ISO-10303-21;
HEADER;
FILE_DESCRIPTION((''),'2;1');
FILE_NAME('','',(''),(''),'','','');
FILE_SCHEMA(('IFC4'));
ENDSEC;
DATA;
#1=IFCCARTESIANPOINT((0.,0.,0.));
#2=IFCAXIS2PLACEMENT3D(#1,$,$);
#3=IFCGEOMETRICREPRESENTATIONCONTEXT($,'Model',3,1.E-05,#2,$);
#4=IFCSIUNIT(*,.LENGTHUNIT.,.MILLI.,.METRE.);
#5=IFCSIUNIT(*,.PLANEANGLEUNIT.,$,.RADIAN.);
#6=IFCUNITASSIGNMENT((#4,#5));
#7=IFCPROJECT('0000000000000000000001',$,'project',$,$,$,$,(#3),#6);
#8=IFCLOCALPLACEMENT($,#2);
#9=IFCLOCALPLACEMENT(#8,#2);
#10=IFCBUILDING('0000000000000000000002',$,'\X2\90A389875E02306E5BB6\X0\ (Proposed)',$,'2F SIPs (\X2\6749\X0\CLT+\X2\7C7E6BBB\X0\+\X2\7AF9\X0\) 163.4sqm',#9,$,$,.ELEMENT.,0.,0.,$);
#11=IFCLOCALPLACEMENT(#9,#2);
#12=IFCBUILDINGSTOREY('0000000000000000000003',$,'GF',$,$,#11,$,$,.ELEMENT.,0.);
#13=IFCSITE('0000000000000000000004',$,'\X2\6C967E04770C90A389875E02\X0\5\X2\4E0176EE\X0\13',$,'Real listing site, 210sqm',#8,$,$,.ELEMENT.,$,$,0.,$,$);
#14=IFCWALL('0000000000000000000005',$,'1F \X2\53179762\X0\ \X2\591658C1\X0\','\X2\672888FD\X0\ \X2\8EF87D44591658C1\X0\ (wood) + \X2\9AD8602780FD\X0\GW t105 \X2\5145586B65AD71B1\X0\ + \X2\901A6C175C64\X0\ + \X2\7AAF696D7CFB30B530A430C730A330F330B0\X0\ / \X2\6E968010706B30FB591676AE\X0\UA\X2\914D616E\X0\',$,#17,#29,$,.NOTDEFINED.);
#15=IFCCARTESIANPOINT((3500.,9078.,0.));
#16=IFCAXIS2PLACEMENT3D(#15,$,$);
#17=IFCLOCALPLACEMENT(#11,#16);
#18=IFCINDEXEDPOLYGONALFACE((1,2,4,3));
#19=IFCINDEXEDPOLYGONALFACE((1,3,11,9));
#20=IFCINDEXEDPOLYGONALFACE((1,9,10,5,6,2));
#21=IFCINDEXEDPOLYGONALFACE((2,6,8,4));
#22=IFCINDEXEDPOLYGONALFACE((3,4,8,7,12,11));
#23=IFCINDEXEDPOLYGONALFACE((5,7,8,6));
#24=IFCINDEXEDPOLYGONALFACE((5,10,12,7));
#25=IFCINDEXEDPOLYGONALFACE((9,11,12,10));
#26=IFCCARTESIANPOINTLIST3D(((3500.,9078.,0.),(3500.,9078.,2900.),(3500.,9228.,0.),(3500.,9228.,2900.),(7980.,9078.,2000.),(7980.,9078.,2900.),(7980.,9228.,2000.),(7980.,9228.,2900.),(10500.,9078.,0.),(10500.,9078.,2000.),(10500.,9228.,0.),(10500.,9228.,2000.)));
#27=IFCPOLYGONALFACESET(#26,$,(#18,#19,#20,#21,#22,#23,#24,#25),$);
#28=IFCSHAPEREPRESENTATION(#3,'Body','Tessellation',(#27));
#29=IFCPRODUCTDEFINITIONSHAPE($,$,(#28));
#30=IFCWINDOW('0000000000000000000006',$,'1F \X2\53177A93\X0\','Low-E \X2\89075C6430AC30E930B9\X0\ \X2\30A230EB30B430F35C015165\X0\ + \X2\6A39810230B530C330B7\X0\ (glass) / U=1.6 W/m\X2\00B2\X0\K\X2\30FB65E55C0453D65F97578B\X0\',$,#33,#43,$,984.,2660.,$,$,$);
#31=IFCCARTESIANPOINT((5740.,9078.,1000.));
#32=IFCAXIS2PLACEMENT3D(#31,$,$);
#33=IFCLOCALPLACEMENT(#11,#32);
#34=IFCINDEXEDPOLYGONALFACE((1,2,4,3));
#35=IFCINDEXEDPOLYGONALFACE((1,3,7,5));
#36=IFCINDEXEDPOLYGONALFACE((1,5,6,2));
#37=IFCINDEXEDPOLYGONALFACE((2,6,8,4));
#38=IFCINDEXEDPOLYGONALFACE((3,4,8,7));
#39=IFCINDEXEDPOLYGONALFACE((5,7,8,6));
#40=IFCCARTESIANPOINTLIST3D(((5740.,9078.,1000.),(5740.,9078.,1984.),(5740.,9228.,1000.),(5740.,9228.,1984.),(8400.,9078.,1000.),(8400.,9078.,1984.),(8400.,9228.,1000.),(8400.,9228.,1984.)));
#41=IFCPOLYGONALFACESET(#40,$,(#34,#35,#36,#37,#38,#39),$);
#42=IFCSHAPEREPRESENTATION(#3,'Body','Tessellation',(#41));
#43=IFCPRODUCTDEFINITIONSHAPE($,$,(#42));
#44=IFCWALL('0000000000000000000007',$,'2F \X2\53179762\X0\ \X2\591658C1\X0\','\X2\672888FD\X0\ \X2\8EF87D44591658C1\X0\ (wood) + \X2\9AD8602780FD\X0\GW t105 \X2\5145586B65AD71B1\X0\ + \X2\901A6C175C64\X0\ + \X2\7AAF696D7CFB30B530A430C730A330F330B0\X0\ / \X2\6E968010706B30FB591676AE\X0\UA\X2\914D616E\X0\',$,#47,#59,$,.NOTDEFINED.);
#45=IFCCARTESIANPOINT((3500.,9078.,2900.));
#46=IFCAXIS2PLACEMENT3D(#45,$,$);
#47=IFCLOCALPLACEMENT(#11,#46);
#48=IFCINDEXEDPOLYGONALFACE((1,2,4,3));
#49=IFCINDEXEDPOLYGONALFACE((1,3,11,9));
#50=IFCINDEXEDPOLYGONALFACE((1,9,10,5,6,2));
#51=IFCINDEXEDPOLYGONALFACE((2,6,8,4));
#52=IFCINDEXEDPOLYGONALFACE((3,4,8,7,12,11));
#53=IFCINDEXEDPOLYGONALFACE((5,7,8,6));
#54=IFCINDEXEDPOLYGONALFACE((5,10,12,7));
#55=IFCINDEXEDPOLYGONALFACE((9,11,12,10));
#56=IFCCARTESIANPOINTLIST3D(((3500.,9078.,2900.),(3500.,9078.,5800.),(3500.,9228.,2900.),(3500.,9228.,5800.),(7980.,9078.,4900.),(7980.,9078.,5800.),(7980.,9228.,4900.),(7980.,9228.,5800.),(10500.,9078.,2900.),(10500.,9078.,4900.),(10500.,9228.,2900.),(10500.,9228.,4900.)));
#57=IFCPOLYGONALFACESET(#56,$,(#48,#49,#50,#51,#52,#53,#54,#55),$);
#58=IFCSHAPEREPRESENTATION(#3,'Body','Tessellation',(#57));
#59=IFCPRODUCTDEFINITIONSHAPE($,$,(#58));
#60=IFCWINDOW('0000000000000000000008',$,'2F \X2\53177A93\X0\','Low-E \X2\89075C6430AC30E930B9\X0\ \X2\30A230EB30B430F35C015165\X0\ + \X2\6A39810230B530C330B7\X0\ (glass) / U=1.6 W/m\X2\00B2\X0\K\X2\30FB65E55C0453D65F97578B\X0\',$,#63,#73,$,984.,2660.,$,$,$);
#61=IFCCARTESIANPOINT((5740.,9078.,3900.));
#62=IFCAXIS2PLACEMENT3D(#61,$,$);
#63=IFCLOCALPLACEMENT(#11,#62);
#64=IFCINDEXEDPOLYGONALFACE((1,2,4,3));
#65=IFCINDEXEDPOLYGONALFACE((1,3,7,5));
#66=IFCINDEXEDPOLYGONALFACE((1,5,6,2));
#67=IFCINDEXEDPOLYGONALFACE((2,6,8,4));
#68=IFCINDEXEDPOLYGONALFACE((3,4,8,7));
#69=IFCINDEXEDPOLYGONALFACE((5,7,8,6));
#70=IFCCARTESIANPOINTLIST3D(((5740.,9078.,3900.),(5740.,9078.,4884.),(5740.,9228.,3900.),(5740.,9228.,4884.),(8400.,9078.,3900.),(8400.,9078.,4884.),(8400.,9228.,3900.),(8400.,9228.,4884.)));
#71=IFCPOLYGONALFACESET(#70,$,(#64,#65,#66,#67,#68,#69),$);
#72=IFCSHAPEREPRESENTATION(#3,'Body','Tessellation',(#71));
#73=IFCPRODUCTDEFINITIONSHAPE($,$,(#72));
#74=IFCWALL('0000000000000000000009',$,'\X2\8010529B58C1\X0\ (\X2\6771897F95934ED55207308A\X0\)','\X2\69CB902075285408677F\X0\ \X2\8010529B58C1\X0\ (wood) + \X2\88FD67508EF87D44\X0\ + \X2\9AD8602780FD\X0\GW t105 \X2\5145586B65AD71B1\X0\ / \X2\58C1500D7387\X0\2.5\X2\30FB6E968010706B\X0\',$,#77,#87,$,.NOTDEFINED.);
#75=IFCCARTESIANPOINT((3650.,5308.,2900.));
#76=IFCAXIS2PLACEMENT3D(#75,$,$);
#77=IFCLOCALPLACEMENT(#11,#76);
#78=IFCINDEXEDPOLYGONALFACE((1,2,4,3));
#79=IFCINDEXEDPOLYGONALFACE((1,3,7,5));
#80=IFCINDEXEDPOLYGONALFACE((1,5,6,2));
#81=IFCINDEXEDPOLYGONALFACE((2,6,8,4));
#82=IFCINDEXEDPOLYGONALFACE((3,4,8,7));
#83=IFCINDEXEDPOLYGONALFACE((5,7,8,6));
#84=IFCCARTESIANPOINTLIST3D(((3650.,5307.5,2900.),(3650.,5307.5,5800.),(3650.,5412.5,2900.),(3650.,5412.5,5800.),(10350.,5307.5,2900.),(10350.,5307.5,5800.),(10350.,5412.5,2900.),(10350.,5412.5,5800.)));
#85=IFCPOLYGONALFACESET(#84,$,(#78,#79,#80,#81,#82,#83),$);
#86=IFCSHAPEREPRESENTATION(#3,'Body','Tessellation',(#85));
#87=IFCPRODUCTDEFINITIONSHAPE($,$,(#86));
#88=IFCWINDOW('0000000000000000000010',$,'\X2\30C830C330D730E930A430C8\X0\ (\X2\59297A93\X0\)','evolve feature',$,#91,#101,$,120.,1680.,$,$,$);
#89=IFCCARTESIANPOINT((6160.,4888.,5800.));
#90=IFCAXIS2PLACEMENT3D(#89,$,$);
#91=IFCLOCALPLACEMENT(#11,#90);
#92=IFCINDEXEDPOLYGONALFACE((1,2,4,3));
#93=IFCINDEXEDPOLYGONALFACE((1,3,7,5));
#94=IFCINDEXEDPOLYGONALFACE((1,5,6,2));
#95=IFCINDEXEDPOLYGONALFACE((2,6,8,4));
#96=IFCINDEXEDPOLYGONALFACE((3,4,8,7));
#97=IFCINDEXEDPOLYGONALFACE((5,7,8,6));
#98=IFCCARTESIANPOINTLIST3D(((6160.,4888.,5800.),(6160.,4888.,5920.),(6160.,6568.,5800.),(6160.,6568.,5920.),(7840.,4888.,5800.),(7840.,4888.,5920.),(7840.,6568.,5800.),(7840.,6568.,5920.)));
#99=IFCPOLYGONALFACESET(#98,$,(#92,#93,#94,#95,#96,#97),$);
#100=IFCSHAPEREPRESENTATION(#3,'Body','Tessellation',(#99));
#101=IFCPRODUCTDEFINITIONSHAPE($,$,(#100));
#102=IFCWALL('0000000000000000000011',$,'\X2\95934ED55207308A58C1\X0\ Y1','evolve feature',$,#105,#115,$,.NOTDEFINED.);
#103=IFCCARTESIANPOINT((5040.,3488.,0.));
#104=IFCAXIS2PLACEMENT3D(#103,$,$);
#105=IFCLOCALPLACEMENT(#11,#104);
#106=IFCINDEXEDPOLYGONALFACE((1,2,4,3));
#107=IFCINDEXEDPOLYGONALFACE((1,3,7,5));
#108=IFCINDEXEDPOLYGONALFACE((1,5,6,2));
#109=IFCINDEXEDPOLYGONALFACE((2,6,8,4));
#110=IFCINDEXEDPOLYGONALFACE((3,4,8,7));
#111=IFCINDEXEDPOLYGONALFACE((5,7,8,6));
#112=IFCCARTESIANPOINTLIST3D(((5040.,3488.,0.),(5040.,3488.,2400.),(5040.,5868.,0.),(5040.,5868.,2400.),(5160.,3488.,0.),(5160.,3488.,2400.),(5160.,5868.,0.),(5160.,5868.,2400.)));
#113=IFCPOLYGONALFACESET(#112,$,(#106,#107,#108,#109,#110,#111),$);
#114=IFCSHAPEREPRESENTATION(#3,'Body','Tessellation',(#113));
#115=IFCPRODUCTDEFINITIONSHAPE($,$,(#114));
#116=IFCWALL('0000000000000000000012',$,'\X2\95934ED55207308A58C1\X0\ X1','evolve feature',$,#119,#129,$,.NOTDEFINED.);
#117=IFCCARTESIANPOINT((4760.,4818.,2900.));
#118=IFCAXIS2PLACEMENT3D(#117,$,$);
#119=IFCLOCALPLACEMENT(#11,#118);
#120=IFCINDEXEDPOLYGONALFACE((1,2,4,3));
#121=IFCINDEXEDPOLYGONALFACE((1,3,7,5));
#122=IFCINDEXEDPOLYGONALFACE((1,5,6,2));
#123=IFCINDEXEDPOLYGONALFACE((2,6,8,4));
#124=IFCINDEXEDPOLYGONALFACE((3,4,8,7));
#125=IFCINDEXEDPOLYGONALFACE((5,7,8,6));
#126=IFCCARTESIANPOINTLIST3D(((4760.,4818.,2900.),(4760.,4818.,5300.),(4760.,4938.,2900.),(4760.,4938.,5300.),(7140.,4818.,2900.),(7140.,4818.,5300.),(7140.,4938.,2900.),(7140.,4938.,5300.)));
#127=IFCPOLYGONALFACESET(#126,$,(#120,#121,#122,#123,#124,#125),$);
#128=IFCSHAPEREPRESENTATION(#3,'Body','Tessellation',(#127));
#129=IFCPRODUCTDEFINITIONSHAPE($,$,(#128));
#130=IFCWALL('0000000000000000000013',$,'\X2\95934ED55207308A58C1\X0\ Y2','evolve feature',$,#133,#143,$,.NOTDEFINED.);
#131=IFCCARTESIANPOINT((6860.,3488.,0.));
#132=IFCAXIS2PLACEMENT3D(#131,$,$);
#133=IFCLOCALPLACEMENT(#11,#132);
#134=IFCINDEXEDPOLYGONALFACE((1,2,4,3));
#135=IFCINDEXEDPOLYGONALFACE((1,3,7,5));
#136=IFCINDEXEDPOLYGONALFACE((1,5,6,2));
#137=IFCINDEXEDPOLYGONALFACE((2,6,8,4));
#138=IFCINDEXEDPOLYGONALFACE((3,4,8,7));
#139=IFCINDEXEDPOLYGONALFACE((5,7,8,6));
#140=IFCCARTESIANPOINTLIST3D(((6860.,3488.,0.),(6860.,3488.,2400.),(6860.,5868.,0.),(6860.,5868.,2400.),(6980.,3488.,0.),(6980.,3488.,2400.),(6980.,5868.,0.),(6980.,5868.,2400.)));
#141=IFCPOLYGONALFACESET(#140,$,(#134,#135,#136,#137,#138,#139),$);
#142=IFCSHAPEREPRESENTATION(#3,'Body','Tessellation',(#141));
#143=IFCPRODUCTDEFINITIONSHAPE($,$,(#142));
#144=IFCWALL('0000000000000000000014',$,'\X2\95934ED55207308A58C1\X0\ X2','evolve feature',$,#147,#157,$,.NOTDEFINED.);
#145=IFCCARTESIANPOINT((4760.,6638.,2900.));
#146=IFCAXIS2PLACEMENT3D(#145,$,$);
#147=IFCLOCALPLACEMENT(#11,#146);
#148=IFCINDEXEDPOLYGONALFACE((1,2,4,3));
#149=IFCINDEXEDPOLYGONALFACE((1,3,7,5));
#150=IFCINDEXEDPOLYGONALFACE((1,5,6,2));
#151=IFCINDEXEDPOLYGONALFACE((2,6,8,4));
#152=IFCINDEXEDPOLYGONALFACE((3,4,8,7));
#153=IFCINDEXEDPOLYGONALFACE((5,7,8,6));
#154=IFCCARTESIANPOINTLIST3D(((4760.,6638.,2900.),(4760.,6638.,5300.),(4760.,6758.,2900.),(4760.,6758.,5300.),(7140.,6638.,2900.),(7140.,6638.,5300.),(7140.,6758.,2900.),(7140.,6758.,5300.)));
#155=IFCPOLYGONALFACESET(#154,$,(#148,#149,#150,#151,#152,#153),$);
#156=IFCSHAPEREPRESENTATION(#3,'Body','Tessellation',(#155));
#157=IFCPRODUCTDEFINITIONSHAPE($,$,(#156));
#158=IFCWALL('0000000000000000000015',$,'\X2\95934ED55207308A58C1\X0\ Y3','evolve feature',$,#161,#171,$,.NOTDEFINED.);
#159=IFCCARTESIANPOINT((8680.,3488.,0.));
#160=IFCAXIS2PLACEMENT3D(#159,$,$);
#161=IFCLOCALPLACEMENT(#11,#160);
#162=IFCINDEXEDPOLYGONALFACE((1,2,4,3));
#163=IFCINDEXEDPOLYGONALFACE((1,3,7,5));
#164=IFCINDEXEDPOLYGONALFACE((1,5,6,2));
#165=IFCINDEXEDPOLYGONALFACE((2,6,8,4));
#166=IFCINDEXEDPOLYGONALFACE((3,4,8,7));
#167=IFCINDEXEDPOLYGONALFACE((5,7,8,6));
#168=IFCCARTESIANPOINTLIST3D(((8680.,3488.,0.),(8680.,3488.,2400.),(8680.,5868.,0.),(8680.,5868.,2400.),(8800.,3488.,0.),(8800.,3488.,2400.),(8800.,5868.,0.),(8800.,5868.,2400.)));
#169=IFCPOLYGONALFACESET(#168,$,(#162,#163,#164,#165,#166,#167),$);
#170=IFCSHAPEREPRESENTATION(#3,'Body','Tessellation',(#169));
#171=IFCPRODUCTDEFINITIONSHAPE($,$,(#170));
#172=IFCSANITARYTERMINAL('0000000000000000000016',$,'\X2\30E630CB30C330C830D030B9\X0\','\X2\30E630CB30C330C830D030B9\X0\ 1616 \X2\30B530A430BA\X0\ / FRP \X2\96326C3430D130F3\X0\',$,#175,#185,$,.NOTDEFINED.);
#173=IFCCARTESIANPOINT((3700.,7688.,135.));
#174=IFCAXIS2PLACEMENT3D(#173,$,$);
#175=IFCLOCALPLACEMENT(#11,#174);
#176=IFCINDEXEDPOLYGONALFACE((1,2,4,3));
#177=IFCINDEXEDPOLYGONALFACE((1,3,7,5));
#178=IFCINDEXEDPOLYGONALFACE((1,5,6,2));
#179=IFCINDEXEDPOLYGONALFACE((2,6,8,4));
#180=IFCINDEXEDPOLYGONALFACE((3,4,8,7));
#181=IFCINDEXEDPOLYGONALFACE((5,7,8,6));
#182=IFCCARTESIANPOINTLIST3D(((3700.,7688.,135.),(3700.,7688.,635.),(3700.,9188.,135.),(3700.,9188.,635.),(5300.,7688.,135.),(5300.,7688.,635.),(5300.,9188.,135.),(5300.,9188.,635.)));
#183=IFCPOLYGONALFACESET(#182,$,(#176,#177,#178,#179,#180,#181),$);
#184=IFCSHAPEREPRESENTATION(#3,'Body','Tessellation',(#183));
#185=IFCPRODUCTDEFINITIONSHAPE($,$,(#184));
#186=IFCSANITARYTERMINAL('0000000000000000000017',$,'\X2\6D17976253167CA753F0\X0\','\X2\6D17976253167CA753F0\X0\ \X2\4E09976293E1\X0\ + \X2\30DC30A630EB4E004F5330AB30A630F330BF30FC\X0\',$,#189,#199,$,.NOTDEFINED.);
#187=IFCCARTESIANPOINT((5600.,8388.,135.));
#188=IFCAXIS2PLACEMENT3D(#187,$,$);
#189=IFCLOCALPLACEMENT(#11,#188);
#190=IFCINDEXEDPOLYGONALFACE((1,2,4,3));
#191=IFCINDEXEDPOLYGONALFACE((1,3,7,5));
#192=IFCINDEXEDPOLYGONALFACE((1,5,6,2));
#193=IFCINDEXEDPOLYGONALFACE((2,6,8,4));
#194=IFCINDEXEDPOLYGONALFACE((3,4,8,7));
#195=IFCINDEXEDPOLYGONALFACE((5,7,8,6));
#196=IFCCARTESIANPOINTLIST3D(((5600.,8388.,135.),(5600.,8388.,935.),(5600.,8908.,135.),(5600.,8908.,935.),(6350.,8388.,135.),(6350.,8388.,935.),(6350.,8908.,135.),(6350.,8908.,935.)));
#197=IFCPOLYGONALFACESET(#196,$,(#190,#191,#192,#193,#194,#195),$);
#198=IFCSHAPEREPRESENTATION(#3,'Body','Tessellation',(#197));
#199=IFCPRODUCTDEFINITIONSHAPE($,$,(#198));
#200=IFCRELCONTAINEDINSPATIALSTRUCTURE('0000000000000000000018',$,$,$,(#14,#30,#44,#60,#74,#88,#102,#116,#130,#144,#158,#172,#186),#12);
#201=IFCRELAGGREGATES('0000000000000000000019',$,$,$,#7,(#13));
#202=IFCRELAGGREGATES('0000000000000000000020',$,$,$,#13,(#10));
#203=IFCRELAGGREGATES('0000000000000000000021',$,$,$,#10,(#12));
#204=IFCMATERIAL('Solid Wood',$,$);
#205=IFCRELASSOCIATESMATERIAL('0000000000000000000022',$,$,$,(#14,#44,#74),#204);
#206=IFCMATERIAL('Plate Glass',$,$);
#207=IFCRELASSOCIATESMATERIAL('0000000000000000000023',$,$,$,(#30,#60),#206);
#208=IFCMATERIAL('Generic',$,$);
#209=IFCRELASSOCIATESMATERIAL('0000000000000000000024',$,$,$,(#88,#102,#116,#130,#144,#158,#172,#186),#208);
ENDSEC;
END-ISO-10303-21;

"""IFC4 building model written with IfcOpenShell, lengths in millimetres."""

from ifc_helpers import new_model, si_unit, frame, frame_2d, origin, place, context, project, spatial, rectangle, extrude, material, element, fill, save


model = new_model("IFC4")

# Units and contexts
model_context = context("Model", 3, precision=1e-05, world=origin())
ifc_project = project(units=[si_unit("LENGTHUNIT", "METRE", prefix="MILLI"), si_unit("PLANEANGLEUNIT", "RADIAN")], contexts=[model_context])

# Site, building, storey
site_placement = place(None, origin())
site = spatial("IfcSite", under=ifc_project, at=site_placement, Name="沖縄県那覇市5丁目13", ObjectType="Real listing site, 210sqm", CompositionType="ELEMENT", RefElevation=0.0)
building_placement = place(site_placement, origin())
building = spatial("IfcBuilding", under=site, at=building_placement, Name="那覇市の家 (Proposed)", ObjectType="2F SIPs (杉CLT+籾殻+竹) 163.4sqm", CompositionType="ELEMENT", ElevationOfRefHeight=0.0, ElevationOfTerrain=0.0)
storey_placement = place(building_placement, origin())
storey = spatial("IfcBuildingStorey", under=building, at=storey_placement, Name="GF", CompositionType="ELEMENT", Elevation=0.0)

# Wall, opening, window
ifc_material_1 = material(Name="Solid Wood")
wall_1_placement = place(storey_placement, frame((3500.0, 9078.0, 0.0)))
wall_1 = element("IfcWall", 1, at=wall_1_placement, inside=storey, material=ifc_material_1, Name="1F 北面 外壁", Description="木製 軸組外壁 (wood) + 高性能GW t105 充填断熱 + 通気層 + 窯業系サイディング / 準耐火・外皮UA配慮", PredefinedType="NOTDEFINED", context=model_context, shape_type="SweptSolid", body=[
    extrude(rectangle(XDim=7000.0, YDim=150.0, at=frame_2d((3500.0, 75.0))), frame((3500.0, 9078.0, 0.0)), (0.0, 0.0, 1.0), 2900.0),
])
opening_1_placement = place(storey_placement, frame((5740.0, 9078.0, 1000.0)))
opening_1 = element("IfcOpeningElement", 2, at=opening_1_placement, cuts=wall_1, PredefinedType="NOTDEFINED", context=model_context, shape_type="SweptSolid", body=[
    extrude(rectangle(XDim=2660.0, YDim=150.0, at=frame_2d((1330.0, 75.0))), frame((5740.0, 9078.0, 1000.0)), (0.0, 0.0, 1.0), 984.0),
])
ifc_material_2 = material(Name="Plate Glass")
window_1_placement = place(storey_placement, frame((5740.0, 9078.0, 1000.0)))
window_1 = element("IfcWindow", 3, at=window_1_placement, inside=storey, material=ifc_material_2, Name="1F 北窓", Description="Low-E 複層ガラス アルゴン封入 + 樹脂サッシ (glass) / U=1.6 W/m²K・日射取得型", OverallHeight=984.0, OverallWidth=2660.0, context=model_context, shape_type="SweptSolid", body=[
    extrude(rectangle(XDim=2660.0, YDim=150.0, at=frame_2d((1330.0, 75.0))), frame((5740.0, 9078.0, 1000.0)), (0.0, 0.0, 1.0), 984.0),
])
fill(opening_1, window_1)

# Wall, opening, window
wall_2_placement = place(storey_placement, frame((3500.0, 9078.0, 2900.0)))
wall_2 = element("IfcWall", 4, at=wall_2_placement, inside=storey, material=ifc_material_1, Name="2F 北面 外壁", Description="木製 軸組外壁 (wood) + 高性能GW t105 充填断熱 + 通気層 + 窯業系サイディング / 準耐火・外皮UA配慮", PredefinedType="NOTDEFINED", context=model_context, shape_type="SweptSolid", body=[
    extrude(rectangle(XDim=7000.0, YDim=150.0, at=frame_2d((3500.0, 75.0))), frame((3500.0, 9078.0, 2900.0)), (0.0, 0.0, 1.0), 2900.0),
])
opening_2_placement = place(storey_placement, frame((5740.0, 9078.0, 3900.0)))
opening_2 = element("IfcOpeningElement", 5, at=opening_2_placement, cuts=wall_2, PredefinedType="NOTDEFINED", context=model_context, shape_type="SweptSolid", body=[
    extrude(rectangle(XDim=2660.0, YDim=150.0, at=frame_2d((1330.0, 75.0))), frame((5740.0, 9078.0, 3900.0)), (0.0, 0.0, 1.0), 984.0),
])
window_2_placement = place(storey_placement, frame((5740.0, 9078.0, 3900.0)))
window_2 = element("IfcWindow", 6, at=window_2_placement, inside=storey, material=ifc_material_2, Name="2F 北窓", Description="Low-E 複層ガラス アルゴン封入 + 樹脂サッシ (glass) / U=1.6 W/m²K・日射取得型", OverallHeight=984.0, OverallWidth=2660.0, context=model_context, shape_type="SweptSolid", body=[
    extrude(rectangle(XDim=2660.0, YDim=150.0, at=frame_2d((1330.0, 75.0))), frame((5740.0, 9078.0, 3900.0)), (0.0, 0.0, 1.0), 984.0),
])
fill(opening_2, window_2)

# Wall
wall_3_placement = place(storey_placement, frame((3650.0, 5308.0, 2900.0)))
element("IfcWall", 7, at=wall_3_placement, inside=storey, material=ifc_material_1, Name="耐力壁 (東西間仕切り)", Description="構造用合板 耐力壁 (wood) + 製材軸組 + 高性能GW t105 充填断熱 / 壁倍率2.5・準耐火", PredefinedType="NOTDEFINED", context=model_context, shape_type="SweptSolid", body=[
    extrude(rectangle(XDim=6700.0, YDim=105.0, at=frame_2d((3350.0, 52.0))), frame((3650.0, 5308.0, 2900.0)), (0.0, 0.0, 1.0), 2900.0),
])

# Window
ifc_material_3 = material(Name="Generic")
window_3_placement = place(storey_placement, frame((6160.0, 4888.0, 5800.0)))
element("IfcWindow", 8, at=window_3_placement, inside=storey, material=ifc_material_3, Name="トップライト (天窓)", Description="evolve feature", OverallHeight=120.0, OverallWidth=1680.0, context=model_context, shape_type="SweptSolid", body=[
    extrude(rectangle(XDim=1680.0, YDim=1680.0, at=frame_2d((840.0, 840.0))), frame((6160.0, 4888.0, 5800.0)), (0.0, 0.0, 1.0), 120.0),
])

# Walls
wall_4_placement = place(storey_placement, frame((5040.0, 3488.0, 0.0)))
element("IfcWall", 9, at=wall_4_placement, inside=storey, material=ifc_material_3, Name="間仕切り壁 Y1", Description="evolve feature", PredefinedType="NOTDEFINED", context=model_context, shape_type="SweptSolid", body=[
    extrude(rectangle(XDim=120.0, YDim=2380.0, at=frame_2d((60.0, 1190.0))), frame((5040.0, 3488.0, 0.0)), (0.0, 0.0, 1.0), 2400.0),
])
wall_5_placement = place(storey_placement, frame((4760.0, 4818.0, 2900.0)))
element("IfcWall", 10, at=wall_5_placement, inside=storey, material=ifc_material_3, Name="間仕切り壁 X1", Description="evolve feature", PredefinedType="NOTDEFINED", context=model_context, shape_type="SweptSolid", body=[
    extrude(rectangle(XDim=2380.0, YDim=120.0, at=frame_2d((1190.0, 60.0))), frame((4760.0, 4818.0, 2900.0)), (0.0, 0.0, 1.0), 2400.0),
])
wall_6_placement = place(storey_placement, frame((6860.0, 3488.0, 0.0)))
element("IfcWall", 11, at=wall_6_placement, inside=storey, material=ifc_material_3, Name="間仕切り壁 Y2", Description="evolve feature", PredefinedType="NOTDEFINED", context=model_context, shape_type="SweptSolid", body=[
    extrude(rectangle(XDim=120.0, YDim=2380.0, at=frame_2d((60.0, 1190.0))), frame((6860.0, 3488.0, 0.0)), (0.0, 0.0, 1.0), 2400.0),
])
wall_7_placement = place(storey_placement, frame((4760.0, 6638.0, 2900.0)))
element("IfcWall", 12, at=wall_7_placement, inside=storey, material=ifc_material_3, Name="間仕切り壁 X2", Description="evolve feature", PredefinedType="NOTDEFINED", context=model_context, shape_type="SweptSolid", body=[
    extrude(rectangle(XDim=2380.0, YDim=120.0, at=frame_2d((1190.0, 60.0))), frame((4760.0, 6638.0, 2900.0)), (0.0, 0.0, 1.0), 2400.0),
])
wall_8_placement = place(storey_placement, frame((8680.0, 3488.0, 0.0)))
element("IfcWall", 13, at=wall_8_placement, inside=storey, material=ifc_material_3, Name="間仕切り壁 Y3", Description="evolve feature", PredefinedType="NOTDEFINED", context=model_context, shape_type="SweptSolid", body=[
    extrude(rectangle(XDim=120.0, YDim=2380.0, at=frame_2d((60.0, 1190.0))), frame((8680.0, 3488.0, 0.0)), (0.0, 0.0, 1.0), 2400.0),
])

# Sanitary terminals
sanitary_terminal_1_placement = place(storey_placement, frame((3700.0, 7688.0, 135.0)))
element("IfcSanitaryTerminal", 14, at=sanitary_terminal_1_placement, inside=storey, material=ifc_material_3, Name="ユニットバス", Description="ユニットバス 1616 サイズ / FRP 防水パン", PredefinedType="NOTDEFINED", context=model_context, shape_type="SweptSolid", body=[
    extrude(rectangle(XDim=1600.0, YDim=1500.0, at=frame_2d((800.0, 750.0))), frame((3700.0, 7688.0, 135.0)), (0.0, 0.0, 1.0), 500.0),
])
sanitary_terminal_2_placement = place(storey_placement, frame((5600.0, 8388.0, 135.0)))
element("IfcSanitaryTerminal", 15, at=sanitary_terminal_2_placement, inside=storey, material=ifc_material_3, Name="洗面化粧台", Description="洗面化粧台 三面鏡 + ボウル一体カウンター", PredefinedType="NOTDEFINED", context=model_context, shape_type="SweptSolid", body=[
    extrude(rectangle(XDim=750.0, YDim=520.0, at=frame_2d((375.0, 260.0))), frame((5600.0, 8388.0, 135.0)), (0.0, 0.0, 1.0), 800.0),
])

save(model, "model.ifc")
